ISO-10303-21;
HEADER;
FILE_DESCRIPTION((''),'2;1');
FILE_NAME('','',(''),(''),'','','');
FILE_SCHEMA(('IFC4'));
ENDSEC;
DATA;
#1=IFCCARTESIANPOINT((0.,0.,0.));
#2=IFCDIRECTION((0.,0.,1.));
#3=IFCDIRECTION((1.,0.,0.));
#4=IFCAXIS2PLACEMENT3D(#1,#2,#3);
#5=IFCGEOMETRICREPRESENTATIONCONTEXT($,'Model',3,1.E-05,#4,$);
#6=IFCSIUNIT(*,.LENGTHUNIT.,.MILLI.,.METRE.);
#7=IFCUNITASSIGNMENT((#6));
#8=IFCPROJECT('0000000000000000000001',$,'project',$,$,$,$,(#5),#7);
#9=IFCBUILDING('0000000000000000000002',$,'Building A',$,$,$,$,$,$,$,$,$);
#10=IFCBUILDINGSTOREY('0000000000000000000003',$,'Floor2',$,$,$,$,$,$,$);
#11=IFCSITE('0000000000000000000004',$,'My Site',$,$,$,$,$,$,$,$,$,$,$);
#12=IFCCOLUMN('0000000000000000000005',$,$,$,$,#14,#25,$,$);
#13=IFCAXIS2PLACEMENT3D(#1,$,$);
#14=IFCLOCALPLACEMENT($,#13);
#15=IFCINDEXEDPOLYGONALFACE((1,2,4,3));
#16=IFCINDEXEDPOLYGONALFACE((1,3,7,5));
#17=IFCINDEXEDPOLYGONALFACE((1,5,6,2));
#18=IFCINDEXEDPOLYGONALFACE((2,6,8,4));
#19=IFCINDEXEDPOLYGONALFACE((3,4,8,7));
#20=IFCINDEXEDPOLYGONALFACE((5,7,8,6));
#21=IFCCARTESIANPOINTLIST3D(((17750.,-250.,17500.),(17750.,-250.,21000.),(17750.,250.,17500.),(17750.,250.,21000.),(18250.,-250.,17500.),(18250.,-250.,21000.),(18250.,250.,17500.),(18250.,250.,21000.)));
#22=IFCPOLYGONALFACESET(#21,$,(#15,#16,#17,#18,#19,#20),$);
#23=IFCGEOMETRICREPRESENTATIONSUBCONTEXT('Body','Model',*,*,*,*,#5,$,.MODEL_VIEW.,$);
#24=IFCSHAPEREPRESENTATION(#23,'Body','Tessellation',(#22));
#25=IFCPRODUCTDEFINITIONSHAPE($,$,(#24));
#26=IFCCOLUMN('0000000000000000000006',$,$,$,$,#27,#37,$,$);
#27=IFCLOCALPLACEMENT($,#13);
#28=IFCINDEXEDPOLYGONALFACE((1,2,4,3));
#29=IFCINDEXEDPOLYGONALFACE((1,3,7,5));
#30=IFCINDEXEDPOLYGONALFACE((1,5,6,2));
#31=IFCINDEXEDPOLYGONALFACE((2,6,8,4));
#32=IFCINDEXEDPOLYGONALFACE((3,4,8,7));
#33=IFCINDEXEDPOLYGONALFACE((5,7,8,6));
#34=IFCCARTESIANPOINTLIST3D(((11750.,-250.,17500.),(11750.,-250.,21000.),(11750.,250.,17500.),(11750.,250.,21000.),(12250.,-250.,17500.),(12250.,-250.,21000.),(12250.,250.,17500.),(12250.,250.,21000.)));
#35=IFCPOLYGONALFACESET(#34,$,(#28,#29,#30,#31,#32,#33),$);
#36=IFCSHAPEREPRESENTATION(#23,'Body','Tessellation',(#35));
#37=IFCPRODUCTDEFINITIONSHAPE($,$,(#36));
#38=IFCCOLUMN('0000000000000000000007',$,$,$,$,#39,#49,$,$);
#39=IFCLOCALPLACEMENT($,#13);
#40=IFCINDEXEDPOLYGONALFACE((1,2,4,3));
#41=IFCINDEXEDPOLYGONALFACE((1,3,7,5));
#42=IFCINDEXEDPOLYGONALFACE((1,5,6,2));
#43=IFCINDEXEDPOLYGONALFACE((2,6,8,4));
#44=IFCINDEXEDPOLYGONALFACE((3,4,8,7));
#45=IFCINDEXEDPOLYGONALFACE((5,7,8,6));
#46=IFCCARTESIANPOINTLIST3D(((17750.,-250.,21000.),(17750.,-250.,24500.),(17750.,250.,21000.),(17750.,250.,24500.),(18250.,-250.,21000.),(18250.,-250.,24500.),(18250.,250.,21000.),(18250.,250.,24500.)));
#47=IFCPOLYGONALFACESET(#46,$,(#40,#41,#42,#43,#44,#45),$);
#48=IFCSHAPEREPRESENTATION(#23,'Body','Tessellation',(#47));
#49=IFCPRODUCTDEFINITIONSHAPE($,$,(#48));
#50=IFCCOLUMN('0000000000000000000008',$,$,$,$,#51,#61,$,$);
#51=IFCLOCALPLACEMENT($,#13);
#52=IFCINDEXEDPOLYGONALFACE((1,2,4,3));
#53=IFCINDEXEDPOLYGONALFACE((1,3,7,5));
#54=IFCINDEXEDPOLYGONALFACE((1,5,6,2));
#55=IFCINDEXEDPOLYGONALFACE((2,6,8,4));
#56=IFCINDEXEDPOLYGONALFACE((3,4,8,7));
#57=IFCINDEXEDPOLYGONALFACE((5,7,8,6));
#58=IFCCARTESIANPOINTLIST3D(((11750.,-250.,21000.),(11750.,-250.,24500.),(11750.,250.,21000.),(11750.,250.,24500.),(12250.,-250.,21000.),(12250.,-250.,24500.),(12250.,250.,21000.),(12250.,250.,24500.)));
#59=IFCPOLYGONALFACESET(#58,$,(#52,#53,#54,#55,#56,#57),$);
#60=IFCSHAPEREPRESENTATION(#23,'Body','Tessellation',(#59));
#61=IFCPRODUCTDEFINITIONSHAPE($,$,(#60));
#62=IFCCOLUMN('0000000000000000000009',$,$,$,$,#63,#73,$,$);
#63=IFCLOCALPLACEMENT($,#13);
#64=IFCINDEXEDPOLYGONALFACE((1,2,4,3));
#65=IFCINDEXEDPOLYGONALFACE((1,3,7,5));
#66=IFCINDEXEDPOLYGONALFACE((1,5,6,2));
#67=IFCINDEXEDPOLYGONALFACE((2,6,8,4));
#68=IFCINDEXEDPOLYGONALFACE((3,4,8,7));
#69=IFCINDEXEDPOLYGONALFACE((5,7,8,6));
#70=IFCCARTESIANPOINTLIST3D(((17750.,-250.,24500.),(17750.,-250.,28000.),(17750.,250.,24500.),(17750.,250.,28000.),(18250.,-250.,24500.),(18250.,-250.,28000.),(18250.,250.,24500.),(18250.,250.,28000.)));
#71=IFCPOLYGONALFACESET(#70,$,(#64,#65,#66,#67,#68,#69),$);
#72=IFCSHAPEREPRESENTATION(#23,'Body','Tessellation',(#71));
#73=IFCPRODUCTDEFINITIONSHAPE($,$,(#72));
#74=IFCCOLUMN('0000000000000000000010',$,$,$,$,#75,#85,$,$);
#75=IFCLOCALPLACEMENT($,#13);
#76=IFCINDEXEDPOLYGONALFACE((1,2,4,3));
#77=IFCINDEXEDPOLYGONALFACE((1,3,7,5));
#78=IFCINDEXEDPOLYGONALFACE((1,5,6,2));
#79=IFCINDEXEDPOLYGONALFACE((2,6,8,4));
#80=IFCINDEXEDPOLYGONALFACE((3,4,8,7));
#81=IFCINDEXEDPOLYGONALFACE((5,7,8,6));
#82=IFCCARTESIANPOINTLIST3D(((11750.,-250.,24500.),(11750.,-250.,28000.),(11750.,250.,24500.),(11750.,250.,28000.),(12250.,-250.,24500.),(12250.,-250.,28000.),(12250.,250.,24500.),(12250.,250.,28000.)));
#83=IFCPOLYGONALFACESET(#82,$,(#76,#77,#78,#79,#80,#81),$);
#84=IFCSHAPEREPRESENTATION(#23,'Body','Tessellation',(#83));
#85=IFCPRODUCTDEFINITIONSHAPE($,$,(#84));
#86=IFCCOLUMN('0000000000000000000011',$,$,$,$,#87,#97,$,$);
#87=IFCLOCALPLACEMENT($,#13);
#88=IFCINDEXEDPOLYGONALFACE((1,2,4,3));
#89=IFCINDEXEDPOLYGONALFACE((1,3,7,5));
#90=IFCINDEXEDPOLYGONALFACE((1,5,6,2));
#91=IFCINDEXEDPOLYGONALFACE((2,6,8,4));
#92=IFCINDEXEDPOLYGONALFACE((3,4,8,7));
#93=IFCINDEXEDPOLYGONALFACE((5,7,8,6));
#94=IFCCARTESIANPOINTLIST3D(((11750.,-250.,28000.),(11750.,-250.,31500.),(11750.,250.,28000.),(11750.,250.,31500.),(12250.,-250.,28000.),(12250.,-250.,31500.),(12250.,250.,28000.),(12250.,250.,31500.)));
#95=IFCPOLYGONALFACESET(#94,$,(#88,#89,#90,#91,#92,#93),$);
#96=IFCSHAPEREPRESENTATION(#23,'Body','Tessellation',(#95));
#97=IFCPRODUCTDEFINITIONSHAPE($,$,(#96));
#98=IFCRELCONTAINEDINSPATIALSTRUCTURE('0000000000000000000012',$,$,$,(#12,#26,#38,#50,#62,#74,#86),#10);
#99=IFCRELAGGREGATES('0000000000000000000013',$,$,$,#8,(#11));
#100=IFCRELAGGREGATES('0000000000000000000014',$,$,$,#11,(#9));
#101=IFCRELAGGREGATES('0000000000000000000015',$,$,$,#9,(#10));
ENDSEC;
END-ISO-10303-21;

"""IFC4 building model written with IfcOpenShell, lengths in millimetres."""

from ifc_helpers import new_model, si_unit, frame, origin_with_axes, place, context, subcontext, project, spatial, line, indexed_curve, outline, extrude, element, save


model = new_model("IFC4")

# Units and contexts
model_context = context("Model", 3, precision=1e-05, world=origin_with_axes())
body_context = subcontext(model_context, "Body", "Model", "MODEL_VIEW")
ifc_project = project(units=[si_unit("LENGTHUNIT", "METRE", prefix="MILLI")], contexts=[model_context])

# Site, building, storey
site = spatial("IfcSite", under=ifc_project, Name="My Site")
building = spatial("IfcBuilding", under=site, Name="Building A")
storey = spatial("IfcBuildingStorey", under=building, Name="Floor2")

# Columns
for number, where, z_axis, x_axis in (
    (1, (18000.0, 0.0, 17500.0), (0.0, 0.0, 1.0), (1.0, 0.0, 0.0)),
    (2, (12000.0, 0.0, 17500.0), (0.0, 0.0, 1.0), (1.0, 0.0, 0.0)),
    (3, (18000.0, 0.0, 21000.0), (0.0, 0.0, 1.0), (1.0, 0.0, 0.0)),
    (4, (12000.0, 0.0, 21000.0), (0.0, 0.0, 1.0), (1.0, 0.0, 0.0)),
    (5, (18000.0, 0.0, 24500.0), (0.0, 0.0, 1.0), (1.0, 0.0, 0.0)),
    (6, (12000.0, 0.0, 24500.0), (0.0, 0.0, 1.0), (1.0, 0.0, 0.0)),
    (7, (12000.0, 0.0, 28000.0), (0.0, 0.0, 1.0), (1.0, 0.0, 0.0)),
):
    element("IfcColumn", number, at=place(None, frame(where, z_axis=z_axis, x_axis=x_axis)), inside=storey, context=body_context, shape_type="SweptSolid", body=[
        extrude(outline(indexed_curve([(-250.0, -250.0), (250.0, -250.0), (250.0, 250.0), (-250.0, 250.0)], segments=[line(1, 2, 3, 4, 1)])), origin_with_axes(), (0.0, 0.0, 1.0), 3500.0),
    ])

save(model, "model.ifc")
